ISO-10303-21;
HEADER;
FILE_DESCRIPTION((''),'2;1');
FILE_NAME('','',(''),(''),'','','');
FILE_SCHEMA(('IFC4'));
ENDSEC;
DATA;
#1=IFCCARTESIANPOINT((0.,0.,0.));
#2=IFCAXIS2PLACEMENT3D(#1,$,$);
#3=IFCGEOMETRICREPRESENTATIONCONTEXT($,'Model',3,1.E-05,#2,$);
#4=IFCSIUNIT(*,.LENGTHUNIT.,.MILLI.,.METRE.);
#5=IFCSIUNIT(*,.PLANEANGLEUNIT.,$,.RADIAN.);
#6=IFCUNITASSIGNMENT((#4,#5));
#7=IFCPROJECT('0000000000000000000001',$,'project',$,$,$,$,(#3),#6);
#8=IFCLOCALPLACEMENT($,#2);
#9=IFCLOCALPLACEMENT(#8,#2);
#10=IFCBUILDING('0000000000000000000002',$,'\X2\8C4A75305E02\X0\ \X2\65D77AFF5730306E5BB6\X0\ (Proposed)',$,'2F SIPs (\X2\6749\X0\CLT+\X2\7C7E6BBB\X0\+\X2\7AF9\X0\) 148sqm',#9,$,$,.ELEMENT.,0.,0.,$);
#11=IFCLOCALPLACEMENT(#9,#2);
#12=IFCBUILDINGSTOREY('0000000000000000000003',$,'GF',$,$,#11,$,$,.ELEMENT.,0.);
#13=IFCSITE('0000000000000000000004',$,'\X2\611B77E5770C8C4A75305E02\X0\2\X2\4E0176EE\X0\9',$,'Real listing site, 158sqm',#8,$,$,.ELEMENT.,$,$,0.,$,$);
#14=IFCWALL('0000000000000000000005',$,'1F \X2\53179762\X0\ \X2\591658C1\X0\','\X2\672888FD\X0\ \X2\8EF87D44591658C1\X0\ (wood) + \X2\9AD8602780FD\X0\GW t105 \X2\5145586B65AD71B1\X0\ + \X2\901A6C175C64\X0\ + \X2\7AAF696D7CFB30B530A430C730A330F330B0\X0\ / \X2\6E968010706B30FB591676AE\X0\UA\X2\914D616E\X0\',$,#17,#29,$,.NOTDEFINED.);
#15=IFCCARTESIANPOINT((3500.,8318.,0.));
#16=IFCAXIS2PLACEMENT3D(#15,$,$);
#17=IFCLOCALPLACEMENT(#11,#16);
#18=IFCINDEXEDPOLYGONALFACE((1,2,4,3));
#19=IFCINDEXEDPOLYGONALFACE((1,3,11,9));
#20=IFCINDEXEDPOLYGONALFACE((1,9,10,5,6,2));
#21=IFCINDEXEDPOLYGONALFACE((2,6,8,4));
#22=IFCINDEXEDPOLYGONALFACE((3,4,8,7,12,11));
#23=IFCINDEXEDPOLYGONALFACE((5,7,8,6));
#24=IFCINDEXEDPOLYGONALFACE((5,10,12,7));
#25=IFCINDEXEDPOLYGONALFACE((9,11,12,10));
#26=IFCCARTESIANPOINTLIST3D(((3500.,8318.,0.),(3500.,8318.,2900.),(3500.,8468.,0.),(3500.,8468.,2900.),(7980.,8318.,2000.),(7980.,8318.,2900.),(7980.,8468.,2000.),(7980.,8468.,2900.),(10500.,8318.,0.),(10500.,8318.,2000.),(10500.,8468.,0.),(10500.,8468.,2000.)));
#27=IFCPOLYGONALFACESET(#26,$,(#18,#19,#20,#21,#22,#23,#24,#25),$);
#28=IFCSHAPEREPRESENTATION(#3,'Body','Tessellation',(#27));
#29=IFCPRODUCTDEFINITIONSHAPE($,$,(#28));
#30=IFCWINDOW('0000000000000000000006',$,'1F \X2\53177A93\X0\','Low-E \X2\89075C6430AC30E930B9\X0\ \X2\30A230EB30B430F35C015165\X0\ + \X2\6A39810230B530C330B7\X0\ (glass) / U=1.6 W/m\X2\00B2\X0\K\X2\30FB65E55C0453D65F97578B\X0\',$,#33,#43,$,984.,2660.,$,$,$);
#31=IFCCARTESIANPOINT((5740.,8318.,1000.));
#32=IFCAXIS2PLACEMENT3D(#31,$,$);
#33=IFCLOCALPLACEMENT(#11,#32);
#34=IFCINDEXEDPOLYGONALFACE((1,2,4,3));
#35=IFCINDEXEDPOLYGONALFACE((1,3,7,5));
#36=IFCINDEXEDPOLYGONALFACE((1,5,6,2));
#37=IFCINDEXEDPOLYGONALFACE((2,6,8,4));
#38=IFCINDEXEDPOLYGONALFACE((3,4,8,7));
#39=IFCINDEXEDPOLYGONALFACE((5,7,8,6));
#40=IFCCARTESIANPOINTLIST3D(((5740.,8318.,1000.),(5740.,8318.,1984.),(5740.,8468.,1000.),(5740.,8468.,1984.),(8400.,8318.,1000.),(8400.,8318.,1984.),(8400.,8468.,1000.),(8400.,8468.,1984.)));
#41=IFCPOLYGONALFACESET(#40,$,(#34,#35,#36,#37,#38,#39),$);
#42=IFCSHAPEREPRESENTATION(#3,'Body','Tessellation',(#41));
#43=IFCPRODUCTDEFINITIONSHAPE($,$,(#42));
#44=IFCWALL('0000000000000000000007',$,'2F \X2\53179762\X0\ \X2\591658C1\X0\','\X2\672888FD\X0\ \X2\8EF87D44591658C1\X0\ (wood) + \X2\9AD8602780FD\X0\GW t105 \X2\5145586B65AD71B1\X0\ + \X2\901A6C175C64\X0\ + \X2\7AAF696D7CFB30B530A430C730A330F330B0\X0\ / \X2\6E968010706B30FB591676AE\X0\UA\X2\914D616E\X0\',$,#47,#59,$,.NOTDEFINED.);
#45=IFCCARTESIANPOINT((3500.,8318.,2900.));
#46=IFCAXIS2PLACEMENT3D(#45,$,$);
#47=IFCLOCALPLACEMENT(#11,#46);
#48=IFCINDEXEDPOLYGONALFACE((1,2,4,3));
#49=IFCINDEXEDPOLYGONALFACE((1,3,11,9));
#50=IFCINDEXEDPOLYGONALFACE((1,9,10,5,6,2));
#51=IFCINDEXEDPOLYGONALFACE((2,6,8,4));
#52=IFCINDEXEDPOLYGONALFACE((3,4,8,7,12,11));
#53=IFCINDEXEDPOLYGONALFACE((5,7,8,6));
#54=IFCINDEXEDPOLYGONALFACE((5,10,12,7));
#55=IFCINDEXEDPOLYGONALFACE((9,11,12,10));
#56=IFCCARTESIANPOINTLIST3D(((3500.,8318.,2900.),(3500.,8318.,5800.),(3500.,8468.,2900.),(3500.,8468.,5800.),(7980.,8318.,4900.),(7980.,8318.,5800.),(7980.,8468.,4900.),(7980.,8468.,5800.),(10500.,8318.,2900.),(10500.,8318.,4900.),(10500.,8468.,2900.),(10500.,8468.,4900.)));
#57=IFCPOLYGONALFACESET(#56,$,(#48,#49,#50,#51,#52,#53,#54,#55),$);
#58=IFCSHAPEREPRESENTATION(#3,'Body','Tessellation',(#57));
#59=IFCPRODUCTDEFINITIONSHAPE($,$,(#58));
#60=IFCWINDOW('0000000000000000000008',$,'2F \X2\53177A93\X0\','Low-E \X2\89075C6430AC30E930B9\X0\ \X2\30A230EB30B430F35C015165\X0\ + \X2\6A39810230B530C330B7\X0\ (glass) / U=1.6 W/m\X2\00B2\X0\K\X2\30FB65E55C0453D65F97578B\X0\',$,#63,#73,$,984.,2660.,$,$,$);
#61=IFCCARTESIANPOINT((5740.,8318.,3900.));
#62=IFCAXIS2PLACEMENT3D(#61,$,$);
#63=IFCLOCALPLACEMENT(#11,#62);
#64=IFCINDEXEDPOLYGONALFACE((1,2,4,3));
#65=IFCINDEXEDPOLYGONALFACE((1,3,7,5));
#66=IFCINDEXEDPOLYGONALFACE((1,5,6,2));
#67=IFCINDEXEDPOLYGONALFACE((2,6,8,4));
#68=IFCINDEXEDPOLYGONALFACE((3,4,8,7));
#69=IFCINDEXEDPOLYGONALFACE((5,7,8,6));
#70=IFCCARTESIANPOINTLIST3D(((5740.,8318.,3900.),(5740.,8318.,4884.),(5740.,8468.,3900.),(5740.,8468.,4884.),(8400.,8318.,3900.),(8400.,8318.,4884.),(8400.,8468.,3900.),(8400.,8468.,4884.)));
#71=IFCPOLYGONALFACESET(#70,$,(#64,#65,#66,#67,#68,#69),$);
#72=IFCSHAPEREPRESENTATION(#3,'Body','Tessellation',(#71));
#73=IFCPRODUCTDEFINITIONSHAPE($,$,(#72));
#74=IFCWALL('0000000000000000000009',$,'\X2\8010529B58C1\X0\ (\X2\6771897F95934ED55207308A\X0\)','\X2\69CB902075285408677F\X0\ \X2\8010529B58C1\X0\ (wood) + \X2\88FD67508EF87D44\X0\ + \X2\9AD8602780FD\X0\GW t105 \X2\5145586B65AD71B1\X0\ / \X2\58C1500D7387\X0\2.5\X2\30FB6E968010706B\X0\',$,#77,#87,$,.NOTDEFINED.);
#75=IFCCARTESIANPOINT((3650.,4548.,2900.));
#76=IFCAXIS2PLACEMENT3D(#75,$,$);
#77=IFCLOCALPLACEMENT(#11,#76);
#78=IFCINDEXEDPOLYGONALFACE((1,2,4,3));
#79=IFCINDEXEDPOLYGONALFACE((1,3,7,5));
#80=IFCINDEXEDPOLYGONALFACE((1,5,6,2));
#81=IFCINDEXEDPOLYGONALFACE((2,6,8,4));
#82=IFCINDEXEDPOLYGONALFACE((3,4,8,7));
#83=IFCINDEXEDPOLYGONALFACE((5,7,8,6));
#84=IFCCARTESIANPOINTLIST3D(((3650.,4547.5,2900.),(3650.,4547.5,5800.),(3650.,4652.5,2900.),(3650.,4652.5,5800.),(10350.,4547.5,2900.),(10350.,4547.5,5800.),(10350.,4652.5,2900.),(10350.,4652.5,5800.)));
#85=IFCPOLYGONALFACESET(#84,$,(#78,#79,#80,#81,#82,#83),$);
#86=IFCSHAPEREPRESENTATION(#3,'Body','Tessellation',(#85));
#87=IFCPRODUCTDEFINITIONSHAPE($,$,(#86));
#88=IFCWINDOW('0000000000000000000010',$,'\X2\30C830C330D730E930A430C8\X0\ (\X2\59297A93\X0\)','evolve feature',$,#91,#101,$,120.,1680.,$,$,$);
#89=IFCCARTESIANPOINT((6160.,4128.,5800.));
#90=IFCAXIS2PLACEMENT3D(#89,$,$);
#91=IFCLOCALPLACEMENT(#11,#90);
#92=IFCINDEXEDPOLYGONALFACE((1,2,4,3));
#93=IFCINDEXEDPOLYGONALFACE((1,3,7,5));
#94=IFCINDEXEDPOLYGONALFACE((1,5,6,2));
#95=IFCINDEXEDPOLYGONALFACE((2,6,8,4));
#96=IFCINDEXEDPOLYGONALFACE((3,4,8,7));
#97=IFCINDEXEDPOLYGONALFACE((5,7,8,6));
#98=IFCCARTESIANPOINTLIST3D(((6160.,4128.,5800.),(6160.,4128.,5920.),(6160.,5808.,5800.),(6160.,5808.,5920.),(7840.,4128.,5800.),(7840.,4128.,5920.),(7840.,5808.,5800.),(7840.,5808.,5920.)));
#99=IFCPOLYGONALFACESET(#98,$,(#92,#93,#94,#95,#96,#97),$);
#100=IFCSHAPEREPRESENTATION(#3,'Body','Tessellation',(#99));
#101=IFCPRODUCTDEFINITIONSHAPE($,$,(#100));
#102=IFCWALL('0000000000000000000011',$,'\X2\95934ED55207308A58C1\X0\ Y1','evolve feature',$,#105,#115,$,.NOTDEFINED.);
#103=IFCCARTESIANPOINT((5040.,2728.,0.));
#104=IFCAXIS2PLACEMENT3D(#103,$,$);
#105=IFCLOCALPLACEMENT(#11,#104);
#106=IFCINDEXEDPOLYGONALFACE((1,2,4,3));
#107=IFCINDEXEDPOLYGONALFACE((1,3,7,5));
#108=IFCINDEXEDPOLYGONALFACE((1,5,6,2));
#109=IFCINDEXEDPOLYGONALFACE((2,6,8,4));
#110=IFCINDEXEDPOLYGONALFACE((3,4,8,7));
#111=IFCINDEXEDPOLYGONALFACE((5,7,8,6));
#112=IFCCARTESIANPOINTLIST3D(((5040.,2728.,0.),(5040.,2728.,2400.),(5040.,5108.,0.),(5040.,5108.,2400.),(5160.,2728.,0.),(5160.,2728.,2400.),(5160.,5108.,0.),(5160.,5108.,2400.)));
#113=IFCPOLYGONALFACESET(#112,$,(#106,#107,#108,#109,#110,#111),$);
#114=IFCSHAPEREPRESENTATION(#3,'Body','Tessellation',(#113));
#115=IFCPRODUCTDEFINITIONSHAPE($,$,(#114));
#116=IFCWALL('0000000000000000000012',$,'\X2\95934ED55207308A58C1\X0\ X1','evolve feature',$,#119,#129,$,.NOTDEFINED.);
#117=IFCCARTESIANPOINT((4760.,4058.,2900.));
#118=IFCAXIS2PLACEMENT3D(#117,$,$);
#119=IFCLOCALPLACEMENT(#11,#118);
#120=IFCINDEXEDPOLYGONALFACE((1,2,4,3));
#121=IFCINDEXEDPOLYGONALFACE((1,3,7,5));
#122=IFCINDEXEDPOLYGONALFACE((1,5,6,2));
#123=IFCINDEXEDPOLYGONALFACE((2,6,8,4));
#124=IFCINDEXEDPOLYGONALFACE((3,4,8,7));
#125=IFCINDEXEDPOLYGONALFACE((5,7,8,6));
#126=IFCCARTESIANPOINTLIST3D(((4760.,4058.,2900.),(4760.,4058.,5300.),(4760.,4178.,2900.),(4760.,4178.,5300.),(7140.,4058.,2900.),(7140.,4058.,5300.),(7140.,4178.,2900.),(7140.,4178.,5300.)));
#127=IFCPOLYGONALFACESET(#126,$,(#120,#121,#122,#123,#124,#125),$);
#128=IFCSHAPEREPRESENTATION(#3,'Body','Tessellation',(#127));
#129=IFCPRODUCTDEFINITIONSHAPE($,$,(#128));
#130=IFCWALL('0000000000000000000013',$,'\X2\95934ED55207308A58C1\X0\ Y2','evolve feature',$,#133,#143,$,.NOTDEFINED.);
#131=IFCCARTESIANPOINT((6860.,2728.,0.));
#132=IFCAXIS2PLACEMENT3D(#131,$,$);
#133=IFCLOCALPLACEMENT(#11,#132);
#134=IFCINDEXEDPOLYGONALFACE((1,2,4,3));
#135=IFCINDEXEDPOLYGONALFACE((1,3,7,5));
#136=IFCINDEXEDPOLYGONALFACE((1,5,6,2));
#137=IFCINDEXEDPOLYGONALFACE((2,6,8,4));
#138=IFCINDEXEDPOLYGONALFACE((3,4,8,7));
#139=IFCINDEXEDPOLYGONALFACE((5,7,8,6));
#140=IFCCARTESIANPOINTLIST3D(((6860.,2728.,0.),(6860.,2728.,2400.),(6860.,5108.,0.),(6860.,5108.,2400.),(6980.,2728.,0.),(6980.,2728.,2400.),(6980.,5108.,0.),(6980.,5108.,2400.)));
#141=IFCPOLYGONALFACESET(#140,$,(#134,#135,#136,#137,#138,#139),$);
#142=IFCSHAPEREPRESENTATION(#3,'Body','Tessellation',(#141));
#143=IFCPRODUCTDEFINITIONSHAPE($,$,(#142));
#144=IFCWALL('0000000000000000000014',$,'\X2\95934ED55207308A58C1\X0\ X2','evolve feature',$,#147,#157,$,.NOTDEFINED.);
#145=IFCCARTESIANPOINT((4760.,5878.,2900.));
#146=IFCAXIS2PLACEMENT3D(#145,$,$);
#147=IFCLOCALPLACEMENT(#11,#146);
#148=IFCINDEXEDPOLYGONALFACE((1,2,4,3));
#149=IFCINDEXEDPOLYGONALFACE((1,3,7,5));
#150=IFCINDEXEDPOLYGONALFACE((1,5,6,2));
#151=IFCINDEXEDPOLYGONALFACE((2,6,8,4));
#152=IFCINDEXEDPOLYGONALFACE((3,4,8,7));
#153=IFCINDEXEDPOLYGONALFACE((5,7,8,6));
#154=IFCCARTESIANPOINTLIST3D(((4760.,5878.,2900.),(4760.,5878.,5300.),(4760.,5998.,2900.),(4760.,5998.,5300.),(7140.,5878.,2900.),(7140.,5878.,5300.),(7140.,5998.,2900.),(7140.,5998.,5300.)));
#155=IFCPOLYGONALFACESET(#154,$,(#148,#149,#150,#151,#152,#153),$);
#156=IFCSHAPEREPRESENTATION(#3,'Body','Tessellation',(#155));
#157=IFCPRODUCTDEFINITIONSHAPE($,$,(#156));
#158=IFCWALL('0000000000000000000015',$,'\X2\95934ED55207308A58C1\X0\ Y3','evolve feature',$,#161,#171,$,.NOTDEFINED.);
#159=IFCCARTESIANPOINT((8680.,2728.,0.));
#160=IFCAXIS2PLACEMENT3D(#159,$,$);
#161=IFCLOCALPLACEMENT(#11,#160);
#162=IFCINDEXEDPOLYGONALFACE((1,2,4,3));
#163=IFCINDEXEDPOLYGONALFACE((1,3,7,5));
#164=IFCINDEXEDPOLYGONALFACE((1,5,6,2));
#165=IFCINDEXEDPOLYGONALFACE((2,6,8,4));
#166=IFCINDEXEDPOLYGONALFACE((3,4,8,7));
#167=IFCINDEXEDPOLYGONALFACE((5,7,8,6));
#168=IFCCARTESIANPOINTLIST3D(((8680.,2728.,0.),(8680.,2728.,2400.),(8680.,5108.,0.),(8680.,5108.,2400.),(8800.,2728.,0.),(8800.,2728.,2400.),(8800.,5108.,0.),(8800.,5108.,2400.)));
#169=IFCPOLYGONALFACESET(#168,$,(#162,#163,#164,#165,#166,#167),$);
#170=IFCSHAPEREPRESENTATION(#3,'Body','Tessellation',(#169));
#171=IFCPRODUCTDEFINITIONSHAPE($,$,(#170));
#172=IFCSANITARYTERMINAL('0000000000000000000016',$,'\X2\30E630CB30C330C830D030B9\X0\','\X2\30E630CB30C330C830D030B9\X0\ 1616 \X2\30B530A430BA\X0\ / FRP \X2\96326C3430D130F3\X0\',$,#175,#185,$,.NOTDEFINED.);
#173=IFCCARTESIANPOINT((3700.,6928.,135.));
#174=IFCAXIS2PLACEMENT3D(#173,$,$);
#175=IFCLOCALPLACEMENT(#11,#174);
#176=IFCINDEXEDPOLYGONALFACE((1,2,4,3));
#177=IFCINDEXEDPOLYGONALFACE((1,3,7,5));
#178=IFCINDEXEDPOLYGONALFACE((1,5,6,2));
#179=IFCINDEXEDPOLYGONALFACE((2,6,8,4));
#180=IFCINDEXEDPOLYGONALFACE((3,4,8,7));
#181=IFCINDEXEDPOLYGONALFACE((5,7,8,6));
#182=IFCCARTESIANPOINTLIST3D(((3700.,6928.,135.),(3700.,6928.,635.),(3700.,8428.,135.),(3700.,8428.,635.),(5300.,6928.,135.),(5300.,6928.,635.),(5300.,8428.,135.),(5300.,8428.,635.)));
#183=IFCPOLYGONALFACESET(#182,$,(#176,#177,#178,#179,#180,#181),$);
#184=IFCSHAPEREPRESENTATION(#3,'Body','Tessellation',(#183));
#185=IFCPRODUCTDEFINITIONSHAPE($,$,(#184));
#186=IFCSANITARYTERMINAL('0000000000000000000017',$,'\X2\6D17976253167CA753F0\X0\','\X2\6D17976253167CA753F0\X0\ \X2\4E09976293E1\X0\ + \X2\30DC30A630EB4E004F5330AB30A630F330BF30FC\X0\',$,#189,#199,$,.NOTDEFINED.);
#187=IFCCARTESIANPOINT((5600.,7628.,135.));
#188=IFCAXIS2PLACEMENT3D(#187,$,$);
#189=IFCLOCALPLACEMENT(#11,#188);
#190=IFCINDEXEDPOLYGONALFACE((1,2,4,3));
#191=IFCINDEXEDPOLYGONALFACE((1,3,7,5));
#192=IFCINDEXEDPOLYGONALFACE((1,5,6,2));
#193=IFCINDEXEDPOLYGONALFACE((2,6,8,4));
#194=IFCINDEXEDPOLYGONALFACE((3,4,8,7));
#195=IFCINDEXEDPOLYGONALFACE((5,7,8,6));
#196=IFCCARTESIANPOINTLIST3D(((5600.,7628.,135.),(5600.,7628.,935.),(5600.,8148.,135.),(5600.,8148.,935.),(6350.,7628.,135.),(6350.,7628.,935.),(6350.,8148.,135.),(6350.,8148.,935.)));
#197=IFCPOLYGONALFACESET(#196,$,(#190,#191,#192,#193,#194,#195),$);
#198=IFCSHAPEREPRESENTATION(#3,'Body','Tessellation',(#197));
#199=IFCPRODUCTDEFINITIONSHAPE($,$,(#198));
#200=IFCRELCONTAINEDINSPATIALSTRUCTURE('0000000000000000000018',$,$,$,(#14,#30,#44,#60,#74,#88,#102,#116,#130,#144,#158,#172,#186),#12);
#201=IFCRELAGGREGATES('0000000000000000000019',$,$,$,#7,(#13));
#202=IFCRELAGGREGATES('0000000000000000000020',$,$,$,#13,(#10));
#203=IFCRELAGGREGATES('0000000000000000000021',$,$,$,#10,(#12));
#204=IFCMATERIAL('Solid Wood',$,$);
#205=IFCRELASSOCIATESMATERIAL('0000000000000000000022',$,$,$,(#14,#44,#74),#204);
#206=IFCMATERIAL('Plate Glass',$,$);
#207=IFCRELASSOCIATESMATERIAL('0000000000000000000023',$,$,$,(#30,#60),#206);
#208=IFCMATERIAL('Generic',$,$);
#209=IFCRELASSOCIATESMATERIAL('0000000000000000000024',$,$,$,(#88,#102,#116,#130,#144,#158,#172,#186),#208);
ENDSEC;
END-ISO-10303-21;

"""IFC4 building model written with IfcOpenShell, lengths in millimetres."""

from ifc_helpers import new_model, si_unit, frame, frame_2d, origin, place, context, project, spatial, rectangle, extrude, material, element, fill, save


model = new_model("IFC4")

# Units and contexts
model_context = context("Model", 3, precision=1e-05, world=origin())
ifc_project = project(units=[si_unit("LENGTHUNIT", "METRE", prefix="MILLI"), si_unit("PLANEANGLEUNIT", "RADIAN")], contexts=[model_context])

# Site, building, storey
site_placement = place(None, origin())
site = spatial("IfcSite", under=ifc_project, at=site_placement, Name="愛知県豊田市2丁目9", ObjectType="Real listing site, 158sqm", CompositionType="ELEMENT", RefElevation=0.0)
building_placement = place(site_placement, origin())
building = spatial("IfcBuilding", under=site, at=building_placement, Name="豊田市 旗竿地の家 (Proposed)", ObjectType="2F SIPs (杉CLT+籾殻+竹) 148sqm", CompositionType="ELEMENT", ElevationOfRefHeight=0.0, ElevationOfTerrain=0.0)
storey_placement = place(building_placement, origin())
storey = spatial("IfcBuildingStorey", under=building, at=storey_placement, Name="GF", CompositionType="ELEMENT", Elevation=0.0)

# Wall, opening, window
ifc_material_1 = material(Name="Solid Wood")
wall_1_placement = place(storey_placement, frame((3500.0, 8318.0, 0.0)))
wall_1 = element("IfcWall", 1, at=wall_1_placement, inside=storey, material=ifc_material_1, Name="1F 北面 外壁", Description="木製 軸組外壁 (wood) + 高性能GW t105 充填断熱 + 通気層 + 窯業系サイディング / 準耐火・外皮UA配慮", PredefinedType="NOTDEFINED", context=model_context, shape_type="SweptSolid", body=[
    extrude(rectangle(XDim=7000.0, YDim=150.0, at=frame_2d((3500.0, 75.0))), frame((3500.0, 8318.0, 0.0)), (0.0, 0.0, 1.0), 2900.0),
])
opening_1_placement = place(storey_placement, frame((5740.0, 8318.0, 1000.0)))
opening_1 = element("IfcOpeningElement", 2, at=opening_1_placement, cuts=wall_1, PredefinedType="NOTDEFINED", context=model_context, shape_type="SweptSolid", body=[
    extrude(rectangle(XDim=2660.0, YDim=150.0, at=frame_2d((1330.0, 75.0))), frame((5740.0, 8318.0, 1000.0)), (0.0, 0.0, 1.0), 984.0),
])
ifc_material_2 = material(Name="Plate Glass")
window_1_placement = place(storey_placement, frame((5740.0, 8318.0, 1000.0)))
window_1 = element("IfcWindow", 3, at=window_1_placement, inside=storey, material=ifc_material_2, Name="1F 北窓", Description="Low-E 複層ガラス アルゴン封入 + 樹脂サッシ (glass) / U=1.6 W/m²K・日射取得型", OverallHeight=984.0, OverallWidth=2660.0, context=model_context, shape_type="SweptSolid", body=[
    extrude(rectangle(XDim=2660.0, YDim=150.0, at=frame_2d((1330.0, 75.0))), frame((5740.0, 8318.0, 1000.0)), (0.0, 0.0, 1.0), 984.0),
])
fill(opening_1, window_1)

# Wall, opening, window
wall_2_placement = place(storey_placement, frame((3500.0, 8318.0, 2900.0)))
wall_2 = element("IfcWall", 4, at=wall_2_placement, inside=storey, material=ifc_material_1, Name="2F 北面 外壁", Description="木製 軸組外壁 (wood) + 高性能GW t105 充填断熱 + 通気層 + 窯業系サイディング / 準耐火・外皮UA配慮", PredefinedType="NOTDEFINED", context=model_context, shape_type="SweptSolid", body=[
    extrude(rectangle(XDim=7000.0, YDim=150.0, at=frame_2d((3500.0, 75.0))), frame((3500.0, 8318.0, 2900.0)), (0.0, 0.0, 1.0), 2900.0),
])
opening_2_placement = place(storey_placement, frame((5740.0, 8318.0, 3900.0)))
opening_2 = element("IfcOpeningElement", 5, at=opening_2_placement, cuts=wall_2, PredefinedType="NOTDEFINED", context=model_context, shape_type="SweptSolid", body=[
    extrude(rectangle(XDim=2660.0, YDim=150.0, at=frame_2d((1330.0, 75.0))), frame((5740.0, 8318.0, 3900.0)), (0.0, 0.0, 1.0), 984.0),
])
window_2_placement = place(storey_placement, frame((5740.0, 8318.0, 3900.0)))
window_2 = element("IfcWindow", 6, at=window_2_placement, inside=storey, material=ifc_material_2, Name="2F 北窓", Description="Low-E 複層ガラス アルゴン封入 + 樹脂サッシ (glass) / U=1.6 W/m²K・日射取得型", OverallHeight=984.0, OverallWidth=2660.0, context=model_context, shape_type="SweptSolid", body=[
    extrude(rectangle(XDim=2660.0, YDim=150.0, at=frame_2d((1330.0, 75.0))), frame((5740.0, 8318.0, 3900.0)), (0.0, 0.0, 1.0), 984.0),
])
fill(opening_2, window_2)

# Wall
wall_3_placement = place(storey_placement, frame((3650.0, 4548.0, 2900.0)))
element("IfcWall", 7, at=wall_3_placement, inside=storey, material=ifc_material_1, Name="耐力壁 (東西間仕切り)", Description="構造用合板 耐力壁 (wood) + 製材軸組 + 高性能GW t105 充填断熱 / 壁倍率2.5・準耐火", PredefinedType="NOTDEFINED", context=model_context, shape_type="SweptSolid", body=[
    extrude(rectangle(XDim=6700.0, YDim=105.0, at=frame_2d((3350.0, 52.0))), frame((3650.0, 4548.0, 2900.0)), (0.0, 0.0, 1.0), 2900.0),
])

# Window
ifc_material_3 = material(Name="Generic")
window_3_placement = place(storey_placement, frame((6160.0, 4128.0, 5800.0)))
element("IfcWindow", 8, at=window_3_placement, inside=storey, material=ifc_material_3, Name="トップライト (天窓)", Description="evolve feature", OverallHeight=120.0, OverallWidth=1680.0, context=model_context, shape_type="SweptSolid", body=[
    extrude(rectangle(XDim=1680.0, YDim=1680.0, at=frame_2d((840.0, 840.0))), frame((6160.0, 4128.0, 5800.0)), (0.0, 0.0, 1.0), 120.0),
])

# Walls
wall_4_placement = place(storey_placement, frame((5040.0, 2728.0, 0.0)))
element("IfcWall", 9, at=wall_4_placement, inside=storey, material=ifc_material_3, Name="間仕切り壁 Y1", Description="evolve feature", PredefinedType="NOTDEFINED", context=model_context, shape_type="SweptSolid", body=[
    extrude(rectangle(XDim=120.0, YDim=2380.0, at=frame_2d((60.0, 1190.0))), frame((5040.0, 2728.0, 0.0)), (0.0, 0.0, 1.0), 2400.0),
])
wall_5_placement = place(storey_placement, frame((4760.0, 4058.0, 2900.0)))
element("IfcWall", 10, at=wall_5_placement, inside=storey, material=ifc_material_3, Name="間仕切り壁 X1", Description="evolve feature", PredefinedType="NOTDEFINED", context=model_context, shape_type="SweptSolid", body=[
    extrude(rectangle(XDim=2380.0, YDim=120.0, at=frame_2d((1190.0, 60.0))), frame((4760.0, 4058.0, 2900.0)), (0.0, 0.0, 1.0), 2400.0),
])
wall_6_placement = place(storey_placement, frame((6860.0, 2728.0, 0.0)))
element("IfcWall", 11, at=wall_6_placement, inside=storey, material=ifc_material_3, Name="間仕切り壁 Y2", Description="evolve feature", PredefinedType="NOTDEFINED", context=model_context, shape_type="SweptSolid", body=[
    extrude(rectangle(XDim=120.0, YDim=2380.0, at=frame_2d((60.0, 1190.0))), frame((6860.0, 2728.0, 0.0)), (0.0, 0.0, 1.0), 2400.0),
])
wall_7_placement = place(storey_placement, frame((4760.0, 5878.0, 2900.0)))
element("IfcWall", 12, at=wall_7_placement, inside=storey, material=ifc_material_3, Name="間仕切り壁 X2", Description="evolve feature", PredefinedType="NOTDEFINED", context=model_context, shape_type="SweptSolid", body=[
    extrude(rectangle(XDim=2380.0, YDim=120.0, at=frame_2d((1190.0, 60.0))), frame((4760.0, 5878.0, 2900.0)), (0.0, 0.0, 1.0), 2400.0),
])
wall_8_placement = place(storey_placement, frame((8680.0, 2728.0, 0.0)))
element("IfcWall", 13, at=wall_8_placement, inside=storey, material=ifc_material_3, Name="間仕切り壁 Y3", Description="evolve feature", PredefinedType="NOTDEFINED", context=model_context, shape_type="SweptSolid", body=[
    extrude(rectangle(XDim=120.0, YDim=2380.0, at=frame_2d((60.0, 1190.0))), frame((8680.0, 2728.0, 0.0)), (0.0, 0.0, 1.0), 2400.0),
])

# Sanitary terminals
sanitary_terminal_1_placement = place(storey_placement, frame((3700.0, 6928.0, 135.0)))
element("IfcSanitaryTerminal", 14, at=sanitary_terminal_1_placement, inside=storey, material=ifc_material_3, Name="ユニットバス", Description="ユニットバス 1616 サイズ / FRP 防水パン", PredefinedType="NOTDEFINED", context=model_context, shape_type="SweptSolid", body=[
    extrude(rectangle(XDim=1600.0, YDim=1500.0, at=frame_2d((800.0, 750.0))), frame((3700.0, 6928.0, 135.0)), (0.0, 0.0, 1.0), 500.0),
])
sanitary_terminal_2_placement = place(storey_placement, frame((5600.0, 7628.0, 135.0)))
element("IfcSanitaryTerminal", 15, at=sanitary_terminal_2_placement, inside=storey, material=ifc_material_3, Name="洗面化粧台", Description="洗面化粧台 三面鏡 + ボウル一体カウンター", PredefinedType="NOTDEFINED", context=model_context, shape_type="SweptSolid", body=[
    extrude(rectangle(XDim=750.0, YDim=520.0, at=frame_2d((375.0, 260.0))), frame((5600.0, 7628.0, 135.0)), (0.0, 0.0, 1.0), 800.0),
])

save(model, "model.ifc")
